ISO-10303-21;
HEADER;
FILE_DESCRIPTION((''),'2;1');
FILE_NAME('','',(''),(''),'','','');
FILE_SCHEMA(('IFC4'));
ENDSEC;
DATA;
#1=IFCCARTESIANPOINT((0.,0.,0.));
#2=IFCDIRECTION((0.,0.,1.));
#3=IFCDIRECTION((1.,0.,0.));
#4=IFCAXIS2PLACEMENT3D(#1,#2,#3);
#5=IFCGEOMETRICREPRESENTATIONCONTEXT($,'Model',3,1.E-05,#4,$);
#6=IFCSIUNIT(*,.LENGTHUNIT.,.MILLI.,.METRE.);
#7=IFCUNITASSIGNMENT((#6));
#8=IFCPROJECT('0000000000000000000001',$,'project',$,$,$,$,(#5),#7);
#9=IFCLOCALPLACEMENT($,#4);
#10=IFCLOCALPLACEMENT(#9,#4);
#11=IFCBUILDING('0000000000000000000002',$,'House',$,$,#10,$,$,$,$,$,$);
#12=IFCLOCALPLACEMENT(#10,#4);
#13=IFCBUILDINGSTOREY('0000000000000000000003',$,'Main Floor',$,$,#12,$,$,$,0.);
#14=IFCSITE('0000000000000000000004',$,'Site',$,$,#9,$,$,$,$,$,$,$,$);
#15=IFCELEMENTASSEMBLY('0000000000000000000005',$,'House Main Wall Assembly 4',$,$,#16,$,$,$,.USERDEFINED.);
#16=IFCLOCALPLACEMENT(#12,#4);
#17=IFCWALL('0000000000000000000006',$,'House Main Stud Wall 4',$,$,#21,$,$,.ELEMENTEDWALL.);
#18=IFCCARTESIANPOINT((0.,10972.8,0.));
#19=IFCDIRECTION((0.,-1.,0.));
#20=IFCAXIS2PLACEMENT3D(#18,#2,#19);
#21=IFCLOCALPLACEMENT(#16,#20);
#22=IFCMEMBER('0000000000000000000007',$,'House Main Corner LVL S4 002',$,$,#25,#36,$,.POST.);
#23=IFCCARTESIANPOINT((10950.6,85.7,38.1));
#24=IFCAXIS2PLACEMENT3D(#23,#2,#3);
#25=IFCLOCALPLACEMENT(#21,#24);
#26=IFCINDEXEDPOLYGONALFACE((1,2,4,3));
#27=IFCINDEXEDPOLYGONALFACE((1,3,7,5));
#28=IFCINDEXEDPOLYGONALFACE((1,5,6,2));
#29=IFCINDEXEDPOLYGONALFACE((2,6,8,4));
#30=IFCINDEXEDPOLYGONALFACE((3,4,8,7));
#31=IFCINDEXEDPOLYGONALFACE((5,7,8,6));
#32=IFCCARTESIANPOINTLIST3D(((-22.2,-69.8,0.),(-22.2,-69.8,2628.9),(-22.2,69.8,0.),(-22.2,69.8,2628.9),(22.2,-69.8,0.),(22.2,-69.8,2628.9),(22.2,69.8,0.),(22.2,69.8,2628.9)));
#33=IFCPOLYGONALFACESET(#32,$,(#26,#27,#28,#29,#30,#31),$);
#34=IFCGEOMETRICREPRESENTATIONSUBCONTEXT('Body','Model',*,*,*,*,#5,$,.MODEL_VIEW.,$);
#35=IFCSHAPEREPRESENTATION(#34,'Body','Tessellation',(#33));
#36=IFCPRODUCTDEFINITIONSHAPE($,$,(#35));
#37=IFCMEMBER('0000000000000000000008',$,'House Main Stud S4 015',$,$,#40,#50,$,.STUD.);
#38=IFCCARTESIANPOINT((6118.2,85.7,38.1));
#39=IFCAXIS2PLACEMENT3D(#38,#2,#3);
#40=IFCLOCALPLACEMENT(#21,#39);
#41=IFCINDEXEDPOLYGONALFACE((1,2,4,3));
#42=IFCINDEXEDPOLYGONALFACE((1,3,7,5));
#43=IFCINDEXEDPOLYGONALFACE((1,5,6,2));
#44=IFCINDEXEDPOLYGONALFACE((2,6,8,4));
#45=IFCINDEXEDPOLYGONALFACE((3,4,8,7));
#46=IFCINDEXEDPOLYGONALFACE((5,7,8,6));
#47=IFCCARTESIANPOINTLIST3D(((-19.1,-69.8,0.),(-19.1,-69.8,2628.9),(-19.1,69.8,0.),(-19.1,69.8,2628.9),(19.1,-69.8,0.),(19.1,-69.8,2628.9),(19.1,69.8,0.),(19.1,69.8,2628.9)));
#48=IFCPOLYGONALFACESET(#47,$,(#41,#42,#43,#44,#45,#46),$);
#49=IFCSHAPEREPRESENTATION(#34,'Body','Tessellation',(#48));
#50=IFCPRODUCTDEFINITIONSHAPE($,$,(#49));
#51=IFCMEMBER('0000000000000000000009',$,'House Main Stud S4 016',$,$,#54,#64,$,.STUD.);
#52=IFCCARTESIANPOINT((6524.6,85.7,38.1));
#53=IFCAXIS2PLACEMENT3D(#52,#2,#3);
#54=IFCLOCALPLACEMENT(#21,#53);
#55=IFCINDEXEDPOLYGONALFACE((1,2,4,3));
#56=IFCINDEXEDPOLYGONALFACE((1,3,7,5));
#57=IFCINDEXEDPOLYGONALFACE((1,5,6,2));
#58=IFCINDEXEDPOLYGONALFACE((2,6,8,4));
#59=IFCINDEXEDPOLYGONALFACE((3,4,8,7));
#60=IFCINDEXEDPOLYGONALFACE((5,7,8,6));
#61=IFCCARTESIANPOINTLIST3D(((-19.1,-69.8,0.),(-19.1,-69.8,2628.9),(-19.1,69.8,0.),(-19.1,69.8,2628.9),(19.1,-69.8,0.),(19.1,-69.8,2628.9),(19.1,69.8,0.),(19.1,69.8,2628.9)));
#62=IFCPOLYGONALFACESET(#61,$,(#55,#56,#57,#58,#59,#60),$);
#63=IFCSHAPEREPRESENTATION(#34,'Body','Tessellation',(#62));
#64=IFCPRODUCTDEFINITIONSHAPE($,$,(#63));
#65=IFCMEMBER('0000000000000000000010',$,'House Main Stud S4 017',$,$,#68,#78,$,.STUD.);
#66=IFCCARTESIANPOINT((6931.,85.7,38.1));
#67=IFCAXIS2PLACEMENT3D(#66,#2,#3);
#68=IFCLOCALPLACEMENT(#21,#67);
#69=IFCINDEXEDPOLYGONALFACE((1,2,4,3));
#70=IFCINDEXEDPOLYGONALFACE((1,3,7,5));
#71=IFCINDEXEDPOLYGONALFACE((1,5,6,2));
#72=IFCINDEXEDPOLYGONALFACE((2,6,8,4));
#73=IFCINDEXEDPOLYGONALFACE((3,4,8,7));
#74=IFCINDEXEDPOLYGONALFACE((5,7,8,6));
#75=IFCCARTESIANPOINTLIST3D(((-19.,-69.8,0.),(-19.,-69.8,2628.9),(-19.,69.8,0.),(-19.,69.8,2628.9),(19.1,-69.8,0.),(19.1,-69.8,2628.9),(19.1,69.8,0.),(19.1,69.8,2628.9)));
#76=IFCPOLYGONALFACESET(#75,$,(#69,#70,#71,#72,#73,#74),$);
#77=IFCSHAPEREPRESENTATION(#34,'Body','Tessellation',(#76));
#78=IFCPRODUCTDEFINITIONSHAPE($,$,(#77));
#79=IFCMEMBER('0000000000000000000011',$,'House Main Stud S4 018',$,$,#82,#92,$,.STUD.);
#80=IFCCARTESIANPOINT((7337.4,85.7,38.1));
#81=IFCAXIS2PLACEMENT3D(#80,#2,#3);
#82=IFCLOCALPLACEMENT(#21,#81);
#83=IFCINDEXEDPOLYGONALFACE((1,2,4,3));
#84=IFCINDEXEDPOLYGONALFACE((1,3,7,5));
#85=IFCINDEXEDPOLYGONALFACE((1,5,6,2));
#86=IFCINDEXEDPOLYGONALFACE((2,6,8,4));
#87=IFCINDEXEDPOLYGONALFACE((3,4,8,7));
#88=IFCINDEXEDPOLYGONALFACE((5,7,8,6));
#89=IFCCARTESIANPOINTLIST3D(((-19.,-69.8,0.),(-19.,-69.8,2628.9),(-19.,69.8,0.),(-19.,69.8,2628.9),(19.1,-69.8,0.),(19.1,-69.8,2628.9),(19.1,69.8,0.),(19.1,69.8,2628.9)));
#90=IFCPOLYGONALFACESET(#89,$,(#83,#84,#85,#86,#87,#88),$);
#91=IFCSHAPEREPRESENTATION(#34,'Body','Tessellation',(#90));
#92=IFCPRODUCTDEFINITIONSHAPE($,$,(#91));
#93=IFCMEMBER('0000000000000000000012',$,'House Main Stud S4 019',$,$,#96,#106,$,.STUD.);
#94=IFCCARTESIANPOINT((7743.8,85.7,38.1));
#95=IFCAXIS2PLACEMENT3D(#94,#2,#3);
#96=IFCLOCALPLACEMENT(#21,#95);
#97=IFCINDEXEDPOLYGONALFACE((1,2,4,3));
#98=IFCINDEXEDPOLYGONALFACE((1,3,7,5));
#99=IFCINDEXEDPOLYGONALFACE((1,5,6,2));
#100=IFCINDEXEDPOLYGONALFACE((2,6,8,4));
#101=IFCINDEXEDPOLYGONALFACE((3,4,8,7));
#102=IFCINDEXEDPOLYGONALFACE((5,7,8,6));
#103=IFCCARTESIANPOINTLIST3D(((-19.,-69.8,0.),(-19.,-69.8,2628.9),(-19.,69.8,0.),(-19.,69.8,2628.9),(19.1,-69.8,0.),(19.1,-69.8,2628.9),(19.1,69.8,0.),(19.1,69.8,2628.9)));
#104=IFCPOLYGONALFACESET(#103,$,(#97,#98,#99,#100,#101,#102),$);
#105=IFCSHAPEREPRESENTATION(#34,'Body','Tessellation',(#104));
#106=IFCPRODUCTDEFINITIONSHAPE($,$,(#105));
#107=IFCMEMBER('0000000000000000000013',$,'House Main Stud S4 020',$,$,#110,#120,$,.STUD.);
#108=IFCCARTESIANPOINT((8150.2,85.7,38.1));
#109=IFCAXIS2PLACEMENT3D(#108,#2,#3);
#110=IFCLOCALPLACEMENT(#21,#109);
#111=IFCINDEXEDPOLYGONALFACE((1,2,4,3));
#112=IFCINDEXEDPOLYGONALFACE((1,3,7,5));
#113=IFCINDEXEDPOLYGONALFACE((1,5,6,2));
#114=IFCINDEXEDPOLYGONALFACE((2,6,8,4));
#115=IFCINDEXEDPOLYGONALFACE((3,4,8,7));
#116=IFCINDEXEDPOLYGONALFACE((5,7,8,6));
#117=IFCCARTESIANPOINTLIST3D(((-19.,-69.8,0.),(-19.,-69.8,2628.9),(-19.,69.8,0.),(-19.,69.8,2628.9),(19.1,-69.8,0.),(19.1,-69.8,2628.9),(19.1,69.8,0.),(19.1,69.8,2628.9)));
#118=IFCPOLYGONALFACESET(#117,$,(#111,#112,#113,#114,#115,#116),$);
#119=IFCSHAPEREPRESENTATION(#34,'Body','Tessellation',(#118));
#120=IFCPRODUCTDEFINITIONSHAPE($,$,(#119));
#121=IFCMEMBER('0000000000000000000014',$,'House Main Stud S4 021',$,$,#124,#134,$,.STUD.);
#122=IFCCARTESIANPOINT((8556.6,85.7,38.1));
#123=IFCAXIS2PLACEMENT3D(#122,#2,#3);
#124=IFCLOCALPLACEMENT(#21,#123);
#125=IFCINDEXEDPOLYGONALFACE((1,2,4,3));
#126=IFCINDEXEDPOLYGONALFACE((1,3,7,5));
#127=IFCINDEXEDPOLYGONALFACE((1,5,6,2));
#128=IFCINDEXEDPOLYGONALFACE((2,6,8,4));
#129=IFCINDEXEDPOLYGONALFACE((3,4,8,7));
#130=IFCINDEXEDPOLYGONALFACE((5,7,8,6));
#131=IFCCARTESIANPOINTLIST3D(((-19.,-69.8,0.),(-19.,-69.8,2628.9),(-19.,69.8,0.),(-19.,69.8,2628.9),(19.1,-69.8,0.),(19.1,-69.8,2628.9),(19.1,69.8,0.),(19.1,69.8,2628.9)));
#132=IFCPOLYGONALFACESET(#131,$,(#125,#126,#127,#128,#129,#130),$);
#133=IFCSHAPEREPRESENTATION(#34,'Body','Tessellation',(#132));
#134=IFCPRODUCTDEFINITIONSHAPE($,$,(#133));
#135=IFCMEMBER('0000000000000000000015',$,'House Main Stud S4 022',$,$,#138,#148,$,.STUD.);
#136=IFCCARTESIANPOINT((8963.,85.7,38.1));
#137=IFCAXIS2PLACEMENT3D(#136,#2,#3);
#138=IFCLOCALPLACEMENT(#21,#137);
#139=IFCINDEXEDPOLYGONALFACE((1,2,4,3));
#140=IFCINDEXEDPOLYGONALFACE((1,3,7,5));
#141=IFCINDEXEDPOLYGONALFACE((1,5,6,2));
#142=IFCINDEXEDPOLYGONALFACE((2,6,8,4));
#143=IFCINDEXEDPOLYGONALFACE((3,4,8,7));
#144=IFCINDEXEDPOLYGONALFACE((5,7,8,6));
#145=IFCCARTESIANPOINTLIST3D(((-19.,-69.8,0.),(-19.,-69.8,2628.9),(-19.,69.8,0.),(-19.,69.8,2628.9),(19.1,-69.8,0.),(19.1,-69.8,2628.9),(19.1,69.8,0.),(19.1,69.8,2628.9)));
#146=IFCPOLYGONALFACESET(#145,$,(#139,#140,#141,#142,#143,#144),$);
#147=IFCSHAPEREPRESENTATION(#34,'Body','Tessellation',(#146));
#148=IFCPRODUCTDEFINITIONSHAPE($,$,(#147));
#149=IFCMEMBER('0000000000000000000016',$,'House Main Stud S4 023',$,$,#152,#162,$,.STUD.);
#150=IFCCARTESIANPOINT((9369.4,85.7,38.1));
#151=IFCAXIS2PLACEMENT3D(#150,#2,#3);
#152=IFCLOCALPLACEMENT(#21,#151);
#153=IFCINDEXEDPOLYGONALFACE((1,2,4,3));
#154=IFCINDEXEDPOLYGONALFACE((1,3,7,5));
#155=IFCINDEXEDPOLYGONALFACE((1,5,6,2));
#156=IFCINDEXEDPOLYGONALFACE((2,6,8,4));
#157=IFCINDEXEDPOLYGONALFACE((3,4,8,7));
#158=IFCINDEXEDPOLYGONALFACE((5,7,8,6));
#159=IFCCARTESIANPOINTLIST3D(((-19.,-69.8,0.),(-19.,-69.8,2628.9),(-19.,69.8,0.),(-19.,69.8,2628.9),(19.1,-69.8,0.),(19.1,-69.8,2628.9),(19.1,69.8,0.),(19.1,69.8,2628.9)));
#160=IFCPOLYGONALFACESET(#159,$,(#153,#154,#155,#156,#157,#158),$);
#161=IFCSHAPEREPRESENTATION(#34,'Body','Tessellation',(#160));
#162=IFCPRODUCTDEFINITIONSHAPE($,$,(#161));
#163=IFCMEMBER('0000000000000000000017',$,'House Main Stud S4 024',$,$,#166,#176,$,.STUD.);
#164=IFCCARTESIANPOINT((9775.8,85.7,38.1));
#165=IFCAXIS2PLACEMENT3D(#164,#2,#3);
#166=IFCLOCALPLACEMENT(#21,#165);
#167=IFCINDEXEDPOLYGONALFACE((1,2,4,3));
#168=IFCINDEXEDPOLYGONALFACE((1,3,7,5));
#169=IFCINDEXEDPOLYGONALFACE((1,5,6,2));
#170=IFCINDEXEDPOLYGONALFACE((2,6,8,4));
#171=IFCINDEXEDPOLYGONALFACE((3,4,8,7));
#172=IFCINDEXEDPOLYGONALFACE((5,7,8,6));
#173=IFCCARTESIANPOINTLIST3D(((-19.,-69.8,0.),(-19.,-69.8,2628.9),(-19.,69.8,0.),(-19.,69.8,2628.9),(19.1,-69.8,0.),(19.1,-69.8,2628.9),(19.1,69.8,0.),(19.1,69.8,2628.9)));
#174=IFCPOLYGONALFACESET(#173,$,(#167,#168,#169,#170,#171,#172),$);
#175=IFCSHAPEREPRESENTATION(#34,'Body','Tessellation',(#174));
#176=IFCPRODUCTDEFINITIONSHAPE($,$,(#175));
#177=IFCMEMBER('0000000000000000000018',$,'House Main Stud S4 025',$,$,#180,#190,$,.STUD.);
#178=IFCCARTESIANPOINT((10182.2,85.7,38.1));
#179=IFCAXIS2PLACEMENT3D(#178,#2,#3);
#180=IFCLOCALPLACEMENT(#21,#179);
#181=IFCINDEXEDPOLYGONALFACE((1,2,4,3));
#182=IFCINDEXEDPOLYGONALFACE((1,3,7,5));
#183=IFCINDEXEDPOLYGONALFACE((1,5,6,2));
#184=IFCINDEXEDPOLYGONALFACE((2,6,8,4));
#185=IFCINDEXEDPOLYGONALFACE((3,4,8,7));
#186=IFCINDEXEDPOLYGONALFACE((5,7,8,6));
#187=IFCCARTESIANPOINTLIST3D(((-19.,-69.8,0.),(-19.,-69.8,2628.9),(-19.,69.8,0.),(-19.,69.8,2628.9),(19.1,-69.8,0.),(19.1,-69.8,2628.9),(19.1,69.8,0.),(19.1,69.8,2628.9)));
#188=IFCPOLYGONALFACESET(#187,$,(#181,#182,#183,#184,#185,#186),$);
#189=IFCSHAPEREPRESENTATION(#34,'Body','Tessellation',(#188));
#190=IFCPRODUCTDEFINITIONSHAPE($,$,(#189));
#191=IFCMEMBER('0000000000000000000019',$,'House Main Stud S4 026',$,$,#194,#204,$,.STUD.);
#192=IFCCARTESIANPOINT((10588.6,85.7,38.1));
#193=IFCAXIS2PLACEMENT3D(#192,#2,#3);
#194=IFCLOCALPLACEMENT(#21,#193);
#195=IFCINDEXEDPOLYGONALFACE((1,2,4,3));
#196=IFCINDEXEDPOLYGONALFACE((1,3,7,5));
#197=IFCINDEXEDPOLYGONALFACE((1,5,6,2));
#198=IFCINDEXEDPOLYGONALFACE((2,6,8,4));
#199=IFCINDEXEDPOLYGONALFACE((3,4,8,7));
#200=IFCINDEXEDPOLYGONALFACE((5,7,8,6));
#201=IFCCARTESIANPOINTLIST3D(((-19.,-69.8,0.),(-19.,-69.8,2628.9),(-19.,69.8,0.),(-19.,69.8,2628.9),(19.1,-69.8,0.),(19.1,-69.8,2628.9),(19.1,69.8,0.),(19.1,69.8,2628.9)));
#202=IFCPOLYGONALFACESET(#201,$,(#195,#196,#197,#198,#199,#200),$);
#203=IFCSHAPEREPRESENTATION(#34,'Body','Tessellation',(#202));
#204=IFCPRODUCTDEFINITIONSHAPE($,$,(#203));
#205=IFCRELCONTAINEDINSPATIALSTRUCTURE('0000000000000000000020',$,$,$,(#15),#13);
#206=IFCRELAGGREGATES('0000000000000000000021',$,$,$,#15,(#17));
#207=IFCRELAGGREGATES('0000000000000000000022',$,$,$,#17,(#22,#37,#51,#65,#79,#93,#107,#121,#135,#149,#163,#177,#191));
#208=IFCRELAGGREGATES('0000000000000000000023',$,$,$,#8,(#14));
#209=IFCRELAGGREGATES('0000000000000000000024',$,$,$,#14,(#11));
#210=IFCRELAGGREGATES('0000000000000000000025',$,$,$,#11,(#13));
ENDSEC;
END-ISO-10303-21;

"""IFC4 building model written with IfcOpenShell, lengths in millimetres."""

from ifc_helpers import new_model, si_unit, frame, origin_with_axes, origin_2d, place, context, subcontext, project, spatial, rectangle, extrude, element, aggregate, save


model = new_model("IFC4")

# Units and contexts
model_context = context("Model", 3, precision=1e-05, world=origin_with_axes())
body_context = subcontext(model_context, "Body", "Model", "MODEL_VIEW")
ifc_project = project(units=[si_unit("LENGTHUNIT", "METRE", prefix="MILLI")], contexts=[model_context])

# Site, building, storey
site_placement = place(None, origin_with_axes())
site = spatial("IfcSite", under=ifc_project, at=site_placement, Name="Site")
building_placement = place(site_placement, origin_with_axes())
building = spatial("IfcBuilding", under=site, at=building_placement, Name="House")
storey_placement = place(building_placement, origin_with_axes())
storey = spatial("IfcBuildingStorey", under=building, at=storey_placement, Name="Main Floor", Elevation=0.0)

# Element assembly, wall, members
assembly_1_placement = place(storey_placement, origin_with_axes())
assembly_1 = element("IfcElementAssembly", 1, at=assembly_1_placement, inside=storey, Name="House Main Wall Assembly 4", PredefinedType="USERDEFINED")
wall_1_placement = place(assembly_1_placement, frame((0.0, 10972.8, 0.0), z_axis=(0.0, 0.0, 1.0), x_axis=(0.0, -1.0, 0.0)))
wall_1 = element("IfcWall", 2, at=wall_1_placement, Name="House Main Stud Wall 4", PredefinedType="ELEMENTEDWALL")
aggregate(assembly_1, [wall_1])
member_1_placement = place(wall_1_placement, frame((10950.6, 85.7, 38.1), z_axis=(0.0, 0.0, 1.0), x_axis=(1.0, 0.0, 0.0)))
member_1 = element("IfcMember", 3, at=member_1_placement, Name="House Main Corner LVL S4 002", PredefinedType="POST", context=body_context, shape_type="SweptSolid", body=[
    extrude(rectangle(XDim=44.5, YDim=139.7, at=origin_2d()), origin_with_axes(), (0.0, 0.0, 1.0), 2628.9),
])
member_2_placement = place(wall_1_placement, frame((6118.2, 85.7, 38.1), z_axis=(0.0, 0.0, 1.0), x_axis=(1.0, 0.0, 0.0)))
member_2 = element("IfcMember", 4, at=member_2_placement, Name="House Main Stud S4 015", PredefinedType="STUD", context=body_context, shape_type="SweptSolid", body=[
    extrude(rectangle(XDim=38.1, YDim=139.7, at=origin_2d()), origin_with_axes(), (0.0, 0.0, 1.0), 2628.9),
])
member_3_placement = place(wall_1_placement, frame((6524.6, 85.7, 38.1), z_axis=(0.0, 0.0, 1.0), x_axis=(1.0, 0.0, 0.0)))
member_3 = element("IfcMember", 5, at=member_3_placement, Name="House Main Stud S4 016", PredefinedType="STUD", context=body_context, shape_type="SweptSolid", body=[
    extrude(rectangle(XDim=38.1, YDim=139.7, at=origin_2d()), origin_with_axes(), (0.0, 0.0, 1.0), 2628.9),
])
member_4_placement = place(wall_1_placement, frame((6931.0, 85.7, 38.1), z_axis=(0.0, 0.0, 1.0), x_axis=(1.0, 0.0, 0.0)))
member_4 = element("IfcMember", 6, at=member_4_placement, Name="House Main Stud S4 017", PredefinedType="STUD", context=body_context, shape_type="SweptSolid", body=[
    extrude(rectangle(XDim=38.1, YDim=139.7, at=origin_2d()), origin_with_axes(), (0.0, 0.0, 1.0), 2628.9),
])
member_5_placement = place(wall_1_placement, frame((7337.4, 85.7, 38.1), z_axis=(0.0, 0.0, 1.0), x_axis=(1.0, 0.0, 0.0)))
member_5 = element("IfcMember", 7, at=member_5_placement, Name="House Main Stud S4 018", PredefinedType="STUD", context=body_context, shape_type="SweptSolid", body=[
    extrude(rectangle(XDim=38.1, YDim=139.7, at=origin_2d()), origin_with_axes(), (0.0, 0.0, 1.0), 2628.9),
])
member_6_placement = place(wall_1_placement, frame((7743.8, 85.7, 38.1), z_axis=(0.0, 0.0, 1.0), x_axis=(1.0, 0.0, 0.0)))
member_6 = element("IfcMember", 8, at=member_6_placement, Name="House Main Stud S4 019", PredefinedType="STUD", context=body_context, shape_type="SweptSolid", body=[
    extrude(rectangle(XDim=38.1, YDim=139.7, at=origin_2d()), origin_with_axes(), (0.0, 0.0, 1.0), 2628.9),
])
member_7_placement = place(wall_1_placement, frame((8150.2, 85.7, 38.1), z_axis=(0.0, 0.0, 1.0), x_axis=(1.0, 0.0, 0.0)))
member_7 = element("IfcMember", 9, at=member_7_placement, Name="House Main Stud S4 020", PredefinedType="STUD", context=body_context, shape_type="SweptSolid", body=[
    extrude(rectangle(XDim=38.1, YDim=139.7, at=origin_2d()), origin_with_axes(), (0.0, 0.0, 1.0), 2628.9),
])
member_8_placement = place(wall_1_placement, frame((8556.6, 85.7, 38.1), z_axis=(0.0, 0.0, 1.0), x_axis=(1.0, 0.0, 0.0)))
member_8 = element("IfcMember", 10, at=member_8_placement, Name="House Main Stud S4 021", PredefinedType="STUD", context=body_context, shape_type="SweptSolid", body=[
    extrude(rectangle(XDim=38.1, YDim=139.7, at=origin_2d()), origin_with_axes(), (0.0, 0.0, 1.0), 2628.9),
])
member_9_placement = place(wall_1_placement, frame((8963.0, 85.7, 38.1), z_axis=(0.0, 0.0, 1.0), x_axis=(1.0, 0.0, 0.0)))
member_9 = element("IfcMember", 11, at=member_9_placement, Name="House Main Stud S4 022", PredefinedType="STUD", context=body_context, shape_type="SweptSolid", body=[
    extrude(rectangle(XDim=38.1, YDim=139.7, at=origin_2d()), origin_with_axes(), (0.0, 0.0, 1.0), 2628.9),
])
member_10_placement = place(wall_1_placement, frame((9369.4, 85.7, 38.1), z_axis=(0.0, 0.0, 1.0), x_axis=(1.0, 0.0, 0.0)))
member_10 = element("IfcMember", 12, at=member_10_placement, Name="House Main Stud S4 023", PredefinedType="STUD", context=body_context, shape_type="SweptSolid", body=[
    extrude(rectangle(XDim=38.1, YDim=139.7, at=origin_2d()), origin_with_axes(), (0.0, 0.0, 1.0), 2628.9),
])
member_11_placement = place(wall_1_placement, frame((9775.8, 85.7, 38.1), z_axis=(0.0, 0.0, 1.0), x_axis=(1.0, 0.0, 0.0)))
member_11 = element("IfcMember", 13, at=member_11_placement, Name="House Main Stud S4 024", PredefinedType="STUD", context=body_context, shape_type="SweptSolid", body=[
    extrude(rectangle(XDim=38.1, YDim=139.7, at=origin_2d()), origin_with_axes(), (0.0, 0.0, 1.0), 2628.9),
])
member_12_placement = place(wall_1_placement, frame((10182.2, 85.7, 38.1), z_axis=(0.0, 0.0, 1.0), x_axis=(1.0, 0.0, 0.0)))
member_12 = element("IfcMember", 14, at=member_12_placement, Name="House Main Stud S4 025", PredefinedType="STUD", context=body_context, shape_type="SweptSolid", body=[
    extrude(rectangle(XDim=38.1, YDim=139.7, at=origin_2d()), origin_with_axes(), (0.0, 0.0, 1.0), 2628.9),
])
member_13_placement = place(wall_1_placement, frame((10588.6, 85.7, 38.1), z_axis=(0.0, 0.0, 1.0), x_axis=(1.0, 0.0, 0.0)))
member_13 = element("IfcMember", 15, at=member_13_placement, Name="House Main Stud S4 026", PredefinedType="STUD", context=body_context, shape_type="SweptSolid", body=[
    extrude(rectangle(XDim=38.1, YDim=139.7, at=origin_2d()), origin_with_axes(), (0.0, 0.0, 1.0), 2628.9),
])
aggregate(wall_1, [member_1, member_2, member_3, member_4, member_5, member_6, member_7, member_8, member_9, member_10, member_11, member_12, member_13])

save(model, "model.ifc")
